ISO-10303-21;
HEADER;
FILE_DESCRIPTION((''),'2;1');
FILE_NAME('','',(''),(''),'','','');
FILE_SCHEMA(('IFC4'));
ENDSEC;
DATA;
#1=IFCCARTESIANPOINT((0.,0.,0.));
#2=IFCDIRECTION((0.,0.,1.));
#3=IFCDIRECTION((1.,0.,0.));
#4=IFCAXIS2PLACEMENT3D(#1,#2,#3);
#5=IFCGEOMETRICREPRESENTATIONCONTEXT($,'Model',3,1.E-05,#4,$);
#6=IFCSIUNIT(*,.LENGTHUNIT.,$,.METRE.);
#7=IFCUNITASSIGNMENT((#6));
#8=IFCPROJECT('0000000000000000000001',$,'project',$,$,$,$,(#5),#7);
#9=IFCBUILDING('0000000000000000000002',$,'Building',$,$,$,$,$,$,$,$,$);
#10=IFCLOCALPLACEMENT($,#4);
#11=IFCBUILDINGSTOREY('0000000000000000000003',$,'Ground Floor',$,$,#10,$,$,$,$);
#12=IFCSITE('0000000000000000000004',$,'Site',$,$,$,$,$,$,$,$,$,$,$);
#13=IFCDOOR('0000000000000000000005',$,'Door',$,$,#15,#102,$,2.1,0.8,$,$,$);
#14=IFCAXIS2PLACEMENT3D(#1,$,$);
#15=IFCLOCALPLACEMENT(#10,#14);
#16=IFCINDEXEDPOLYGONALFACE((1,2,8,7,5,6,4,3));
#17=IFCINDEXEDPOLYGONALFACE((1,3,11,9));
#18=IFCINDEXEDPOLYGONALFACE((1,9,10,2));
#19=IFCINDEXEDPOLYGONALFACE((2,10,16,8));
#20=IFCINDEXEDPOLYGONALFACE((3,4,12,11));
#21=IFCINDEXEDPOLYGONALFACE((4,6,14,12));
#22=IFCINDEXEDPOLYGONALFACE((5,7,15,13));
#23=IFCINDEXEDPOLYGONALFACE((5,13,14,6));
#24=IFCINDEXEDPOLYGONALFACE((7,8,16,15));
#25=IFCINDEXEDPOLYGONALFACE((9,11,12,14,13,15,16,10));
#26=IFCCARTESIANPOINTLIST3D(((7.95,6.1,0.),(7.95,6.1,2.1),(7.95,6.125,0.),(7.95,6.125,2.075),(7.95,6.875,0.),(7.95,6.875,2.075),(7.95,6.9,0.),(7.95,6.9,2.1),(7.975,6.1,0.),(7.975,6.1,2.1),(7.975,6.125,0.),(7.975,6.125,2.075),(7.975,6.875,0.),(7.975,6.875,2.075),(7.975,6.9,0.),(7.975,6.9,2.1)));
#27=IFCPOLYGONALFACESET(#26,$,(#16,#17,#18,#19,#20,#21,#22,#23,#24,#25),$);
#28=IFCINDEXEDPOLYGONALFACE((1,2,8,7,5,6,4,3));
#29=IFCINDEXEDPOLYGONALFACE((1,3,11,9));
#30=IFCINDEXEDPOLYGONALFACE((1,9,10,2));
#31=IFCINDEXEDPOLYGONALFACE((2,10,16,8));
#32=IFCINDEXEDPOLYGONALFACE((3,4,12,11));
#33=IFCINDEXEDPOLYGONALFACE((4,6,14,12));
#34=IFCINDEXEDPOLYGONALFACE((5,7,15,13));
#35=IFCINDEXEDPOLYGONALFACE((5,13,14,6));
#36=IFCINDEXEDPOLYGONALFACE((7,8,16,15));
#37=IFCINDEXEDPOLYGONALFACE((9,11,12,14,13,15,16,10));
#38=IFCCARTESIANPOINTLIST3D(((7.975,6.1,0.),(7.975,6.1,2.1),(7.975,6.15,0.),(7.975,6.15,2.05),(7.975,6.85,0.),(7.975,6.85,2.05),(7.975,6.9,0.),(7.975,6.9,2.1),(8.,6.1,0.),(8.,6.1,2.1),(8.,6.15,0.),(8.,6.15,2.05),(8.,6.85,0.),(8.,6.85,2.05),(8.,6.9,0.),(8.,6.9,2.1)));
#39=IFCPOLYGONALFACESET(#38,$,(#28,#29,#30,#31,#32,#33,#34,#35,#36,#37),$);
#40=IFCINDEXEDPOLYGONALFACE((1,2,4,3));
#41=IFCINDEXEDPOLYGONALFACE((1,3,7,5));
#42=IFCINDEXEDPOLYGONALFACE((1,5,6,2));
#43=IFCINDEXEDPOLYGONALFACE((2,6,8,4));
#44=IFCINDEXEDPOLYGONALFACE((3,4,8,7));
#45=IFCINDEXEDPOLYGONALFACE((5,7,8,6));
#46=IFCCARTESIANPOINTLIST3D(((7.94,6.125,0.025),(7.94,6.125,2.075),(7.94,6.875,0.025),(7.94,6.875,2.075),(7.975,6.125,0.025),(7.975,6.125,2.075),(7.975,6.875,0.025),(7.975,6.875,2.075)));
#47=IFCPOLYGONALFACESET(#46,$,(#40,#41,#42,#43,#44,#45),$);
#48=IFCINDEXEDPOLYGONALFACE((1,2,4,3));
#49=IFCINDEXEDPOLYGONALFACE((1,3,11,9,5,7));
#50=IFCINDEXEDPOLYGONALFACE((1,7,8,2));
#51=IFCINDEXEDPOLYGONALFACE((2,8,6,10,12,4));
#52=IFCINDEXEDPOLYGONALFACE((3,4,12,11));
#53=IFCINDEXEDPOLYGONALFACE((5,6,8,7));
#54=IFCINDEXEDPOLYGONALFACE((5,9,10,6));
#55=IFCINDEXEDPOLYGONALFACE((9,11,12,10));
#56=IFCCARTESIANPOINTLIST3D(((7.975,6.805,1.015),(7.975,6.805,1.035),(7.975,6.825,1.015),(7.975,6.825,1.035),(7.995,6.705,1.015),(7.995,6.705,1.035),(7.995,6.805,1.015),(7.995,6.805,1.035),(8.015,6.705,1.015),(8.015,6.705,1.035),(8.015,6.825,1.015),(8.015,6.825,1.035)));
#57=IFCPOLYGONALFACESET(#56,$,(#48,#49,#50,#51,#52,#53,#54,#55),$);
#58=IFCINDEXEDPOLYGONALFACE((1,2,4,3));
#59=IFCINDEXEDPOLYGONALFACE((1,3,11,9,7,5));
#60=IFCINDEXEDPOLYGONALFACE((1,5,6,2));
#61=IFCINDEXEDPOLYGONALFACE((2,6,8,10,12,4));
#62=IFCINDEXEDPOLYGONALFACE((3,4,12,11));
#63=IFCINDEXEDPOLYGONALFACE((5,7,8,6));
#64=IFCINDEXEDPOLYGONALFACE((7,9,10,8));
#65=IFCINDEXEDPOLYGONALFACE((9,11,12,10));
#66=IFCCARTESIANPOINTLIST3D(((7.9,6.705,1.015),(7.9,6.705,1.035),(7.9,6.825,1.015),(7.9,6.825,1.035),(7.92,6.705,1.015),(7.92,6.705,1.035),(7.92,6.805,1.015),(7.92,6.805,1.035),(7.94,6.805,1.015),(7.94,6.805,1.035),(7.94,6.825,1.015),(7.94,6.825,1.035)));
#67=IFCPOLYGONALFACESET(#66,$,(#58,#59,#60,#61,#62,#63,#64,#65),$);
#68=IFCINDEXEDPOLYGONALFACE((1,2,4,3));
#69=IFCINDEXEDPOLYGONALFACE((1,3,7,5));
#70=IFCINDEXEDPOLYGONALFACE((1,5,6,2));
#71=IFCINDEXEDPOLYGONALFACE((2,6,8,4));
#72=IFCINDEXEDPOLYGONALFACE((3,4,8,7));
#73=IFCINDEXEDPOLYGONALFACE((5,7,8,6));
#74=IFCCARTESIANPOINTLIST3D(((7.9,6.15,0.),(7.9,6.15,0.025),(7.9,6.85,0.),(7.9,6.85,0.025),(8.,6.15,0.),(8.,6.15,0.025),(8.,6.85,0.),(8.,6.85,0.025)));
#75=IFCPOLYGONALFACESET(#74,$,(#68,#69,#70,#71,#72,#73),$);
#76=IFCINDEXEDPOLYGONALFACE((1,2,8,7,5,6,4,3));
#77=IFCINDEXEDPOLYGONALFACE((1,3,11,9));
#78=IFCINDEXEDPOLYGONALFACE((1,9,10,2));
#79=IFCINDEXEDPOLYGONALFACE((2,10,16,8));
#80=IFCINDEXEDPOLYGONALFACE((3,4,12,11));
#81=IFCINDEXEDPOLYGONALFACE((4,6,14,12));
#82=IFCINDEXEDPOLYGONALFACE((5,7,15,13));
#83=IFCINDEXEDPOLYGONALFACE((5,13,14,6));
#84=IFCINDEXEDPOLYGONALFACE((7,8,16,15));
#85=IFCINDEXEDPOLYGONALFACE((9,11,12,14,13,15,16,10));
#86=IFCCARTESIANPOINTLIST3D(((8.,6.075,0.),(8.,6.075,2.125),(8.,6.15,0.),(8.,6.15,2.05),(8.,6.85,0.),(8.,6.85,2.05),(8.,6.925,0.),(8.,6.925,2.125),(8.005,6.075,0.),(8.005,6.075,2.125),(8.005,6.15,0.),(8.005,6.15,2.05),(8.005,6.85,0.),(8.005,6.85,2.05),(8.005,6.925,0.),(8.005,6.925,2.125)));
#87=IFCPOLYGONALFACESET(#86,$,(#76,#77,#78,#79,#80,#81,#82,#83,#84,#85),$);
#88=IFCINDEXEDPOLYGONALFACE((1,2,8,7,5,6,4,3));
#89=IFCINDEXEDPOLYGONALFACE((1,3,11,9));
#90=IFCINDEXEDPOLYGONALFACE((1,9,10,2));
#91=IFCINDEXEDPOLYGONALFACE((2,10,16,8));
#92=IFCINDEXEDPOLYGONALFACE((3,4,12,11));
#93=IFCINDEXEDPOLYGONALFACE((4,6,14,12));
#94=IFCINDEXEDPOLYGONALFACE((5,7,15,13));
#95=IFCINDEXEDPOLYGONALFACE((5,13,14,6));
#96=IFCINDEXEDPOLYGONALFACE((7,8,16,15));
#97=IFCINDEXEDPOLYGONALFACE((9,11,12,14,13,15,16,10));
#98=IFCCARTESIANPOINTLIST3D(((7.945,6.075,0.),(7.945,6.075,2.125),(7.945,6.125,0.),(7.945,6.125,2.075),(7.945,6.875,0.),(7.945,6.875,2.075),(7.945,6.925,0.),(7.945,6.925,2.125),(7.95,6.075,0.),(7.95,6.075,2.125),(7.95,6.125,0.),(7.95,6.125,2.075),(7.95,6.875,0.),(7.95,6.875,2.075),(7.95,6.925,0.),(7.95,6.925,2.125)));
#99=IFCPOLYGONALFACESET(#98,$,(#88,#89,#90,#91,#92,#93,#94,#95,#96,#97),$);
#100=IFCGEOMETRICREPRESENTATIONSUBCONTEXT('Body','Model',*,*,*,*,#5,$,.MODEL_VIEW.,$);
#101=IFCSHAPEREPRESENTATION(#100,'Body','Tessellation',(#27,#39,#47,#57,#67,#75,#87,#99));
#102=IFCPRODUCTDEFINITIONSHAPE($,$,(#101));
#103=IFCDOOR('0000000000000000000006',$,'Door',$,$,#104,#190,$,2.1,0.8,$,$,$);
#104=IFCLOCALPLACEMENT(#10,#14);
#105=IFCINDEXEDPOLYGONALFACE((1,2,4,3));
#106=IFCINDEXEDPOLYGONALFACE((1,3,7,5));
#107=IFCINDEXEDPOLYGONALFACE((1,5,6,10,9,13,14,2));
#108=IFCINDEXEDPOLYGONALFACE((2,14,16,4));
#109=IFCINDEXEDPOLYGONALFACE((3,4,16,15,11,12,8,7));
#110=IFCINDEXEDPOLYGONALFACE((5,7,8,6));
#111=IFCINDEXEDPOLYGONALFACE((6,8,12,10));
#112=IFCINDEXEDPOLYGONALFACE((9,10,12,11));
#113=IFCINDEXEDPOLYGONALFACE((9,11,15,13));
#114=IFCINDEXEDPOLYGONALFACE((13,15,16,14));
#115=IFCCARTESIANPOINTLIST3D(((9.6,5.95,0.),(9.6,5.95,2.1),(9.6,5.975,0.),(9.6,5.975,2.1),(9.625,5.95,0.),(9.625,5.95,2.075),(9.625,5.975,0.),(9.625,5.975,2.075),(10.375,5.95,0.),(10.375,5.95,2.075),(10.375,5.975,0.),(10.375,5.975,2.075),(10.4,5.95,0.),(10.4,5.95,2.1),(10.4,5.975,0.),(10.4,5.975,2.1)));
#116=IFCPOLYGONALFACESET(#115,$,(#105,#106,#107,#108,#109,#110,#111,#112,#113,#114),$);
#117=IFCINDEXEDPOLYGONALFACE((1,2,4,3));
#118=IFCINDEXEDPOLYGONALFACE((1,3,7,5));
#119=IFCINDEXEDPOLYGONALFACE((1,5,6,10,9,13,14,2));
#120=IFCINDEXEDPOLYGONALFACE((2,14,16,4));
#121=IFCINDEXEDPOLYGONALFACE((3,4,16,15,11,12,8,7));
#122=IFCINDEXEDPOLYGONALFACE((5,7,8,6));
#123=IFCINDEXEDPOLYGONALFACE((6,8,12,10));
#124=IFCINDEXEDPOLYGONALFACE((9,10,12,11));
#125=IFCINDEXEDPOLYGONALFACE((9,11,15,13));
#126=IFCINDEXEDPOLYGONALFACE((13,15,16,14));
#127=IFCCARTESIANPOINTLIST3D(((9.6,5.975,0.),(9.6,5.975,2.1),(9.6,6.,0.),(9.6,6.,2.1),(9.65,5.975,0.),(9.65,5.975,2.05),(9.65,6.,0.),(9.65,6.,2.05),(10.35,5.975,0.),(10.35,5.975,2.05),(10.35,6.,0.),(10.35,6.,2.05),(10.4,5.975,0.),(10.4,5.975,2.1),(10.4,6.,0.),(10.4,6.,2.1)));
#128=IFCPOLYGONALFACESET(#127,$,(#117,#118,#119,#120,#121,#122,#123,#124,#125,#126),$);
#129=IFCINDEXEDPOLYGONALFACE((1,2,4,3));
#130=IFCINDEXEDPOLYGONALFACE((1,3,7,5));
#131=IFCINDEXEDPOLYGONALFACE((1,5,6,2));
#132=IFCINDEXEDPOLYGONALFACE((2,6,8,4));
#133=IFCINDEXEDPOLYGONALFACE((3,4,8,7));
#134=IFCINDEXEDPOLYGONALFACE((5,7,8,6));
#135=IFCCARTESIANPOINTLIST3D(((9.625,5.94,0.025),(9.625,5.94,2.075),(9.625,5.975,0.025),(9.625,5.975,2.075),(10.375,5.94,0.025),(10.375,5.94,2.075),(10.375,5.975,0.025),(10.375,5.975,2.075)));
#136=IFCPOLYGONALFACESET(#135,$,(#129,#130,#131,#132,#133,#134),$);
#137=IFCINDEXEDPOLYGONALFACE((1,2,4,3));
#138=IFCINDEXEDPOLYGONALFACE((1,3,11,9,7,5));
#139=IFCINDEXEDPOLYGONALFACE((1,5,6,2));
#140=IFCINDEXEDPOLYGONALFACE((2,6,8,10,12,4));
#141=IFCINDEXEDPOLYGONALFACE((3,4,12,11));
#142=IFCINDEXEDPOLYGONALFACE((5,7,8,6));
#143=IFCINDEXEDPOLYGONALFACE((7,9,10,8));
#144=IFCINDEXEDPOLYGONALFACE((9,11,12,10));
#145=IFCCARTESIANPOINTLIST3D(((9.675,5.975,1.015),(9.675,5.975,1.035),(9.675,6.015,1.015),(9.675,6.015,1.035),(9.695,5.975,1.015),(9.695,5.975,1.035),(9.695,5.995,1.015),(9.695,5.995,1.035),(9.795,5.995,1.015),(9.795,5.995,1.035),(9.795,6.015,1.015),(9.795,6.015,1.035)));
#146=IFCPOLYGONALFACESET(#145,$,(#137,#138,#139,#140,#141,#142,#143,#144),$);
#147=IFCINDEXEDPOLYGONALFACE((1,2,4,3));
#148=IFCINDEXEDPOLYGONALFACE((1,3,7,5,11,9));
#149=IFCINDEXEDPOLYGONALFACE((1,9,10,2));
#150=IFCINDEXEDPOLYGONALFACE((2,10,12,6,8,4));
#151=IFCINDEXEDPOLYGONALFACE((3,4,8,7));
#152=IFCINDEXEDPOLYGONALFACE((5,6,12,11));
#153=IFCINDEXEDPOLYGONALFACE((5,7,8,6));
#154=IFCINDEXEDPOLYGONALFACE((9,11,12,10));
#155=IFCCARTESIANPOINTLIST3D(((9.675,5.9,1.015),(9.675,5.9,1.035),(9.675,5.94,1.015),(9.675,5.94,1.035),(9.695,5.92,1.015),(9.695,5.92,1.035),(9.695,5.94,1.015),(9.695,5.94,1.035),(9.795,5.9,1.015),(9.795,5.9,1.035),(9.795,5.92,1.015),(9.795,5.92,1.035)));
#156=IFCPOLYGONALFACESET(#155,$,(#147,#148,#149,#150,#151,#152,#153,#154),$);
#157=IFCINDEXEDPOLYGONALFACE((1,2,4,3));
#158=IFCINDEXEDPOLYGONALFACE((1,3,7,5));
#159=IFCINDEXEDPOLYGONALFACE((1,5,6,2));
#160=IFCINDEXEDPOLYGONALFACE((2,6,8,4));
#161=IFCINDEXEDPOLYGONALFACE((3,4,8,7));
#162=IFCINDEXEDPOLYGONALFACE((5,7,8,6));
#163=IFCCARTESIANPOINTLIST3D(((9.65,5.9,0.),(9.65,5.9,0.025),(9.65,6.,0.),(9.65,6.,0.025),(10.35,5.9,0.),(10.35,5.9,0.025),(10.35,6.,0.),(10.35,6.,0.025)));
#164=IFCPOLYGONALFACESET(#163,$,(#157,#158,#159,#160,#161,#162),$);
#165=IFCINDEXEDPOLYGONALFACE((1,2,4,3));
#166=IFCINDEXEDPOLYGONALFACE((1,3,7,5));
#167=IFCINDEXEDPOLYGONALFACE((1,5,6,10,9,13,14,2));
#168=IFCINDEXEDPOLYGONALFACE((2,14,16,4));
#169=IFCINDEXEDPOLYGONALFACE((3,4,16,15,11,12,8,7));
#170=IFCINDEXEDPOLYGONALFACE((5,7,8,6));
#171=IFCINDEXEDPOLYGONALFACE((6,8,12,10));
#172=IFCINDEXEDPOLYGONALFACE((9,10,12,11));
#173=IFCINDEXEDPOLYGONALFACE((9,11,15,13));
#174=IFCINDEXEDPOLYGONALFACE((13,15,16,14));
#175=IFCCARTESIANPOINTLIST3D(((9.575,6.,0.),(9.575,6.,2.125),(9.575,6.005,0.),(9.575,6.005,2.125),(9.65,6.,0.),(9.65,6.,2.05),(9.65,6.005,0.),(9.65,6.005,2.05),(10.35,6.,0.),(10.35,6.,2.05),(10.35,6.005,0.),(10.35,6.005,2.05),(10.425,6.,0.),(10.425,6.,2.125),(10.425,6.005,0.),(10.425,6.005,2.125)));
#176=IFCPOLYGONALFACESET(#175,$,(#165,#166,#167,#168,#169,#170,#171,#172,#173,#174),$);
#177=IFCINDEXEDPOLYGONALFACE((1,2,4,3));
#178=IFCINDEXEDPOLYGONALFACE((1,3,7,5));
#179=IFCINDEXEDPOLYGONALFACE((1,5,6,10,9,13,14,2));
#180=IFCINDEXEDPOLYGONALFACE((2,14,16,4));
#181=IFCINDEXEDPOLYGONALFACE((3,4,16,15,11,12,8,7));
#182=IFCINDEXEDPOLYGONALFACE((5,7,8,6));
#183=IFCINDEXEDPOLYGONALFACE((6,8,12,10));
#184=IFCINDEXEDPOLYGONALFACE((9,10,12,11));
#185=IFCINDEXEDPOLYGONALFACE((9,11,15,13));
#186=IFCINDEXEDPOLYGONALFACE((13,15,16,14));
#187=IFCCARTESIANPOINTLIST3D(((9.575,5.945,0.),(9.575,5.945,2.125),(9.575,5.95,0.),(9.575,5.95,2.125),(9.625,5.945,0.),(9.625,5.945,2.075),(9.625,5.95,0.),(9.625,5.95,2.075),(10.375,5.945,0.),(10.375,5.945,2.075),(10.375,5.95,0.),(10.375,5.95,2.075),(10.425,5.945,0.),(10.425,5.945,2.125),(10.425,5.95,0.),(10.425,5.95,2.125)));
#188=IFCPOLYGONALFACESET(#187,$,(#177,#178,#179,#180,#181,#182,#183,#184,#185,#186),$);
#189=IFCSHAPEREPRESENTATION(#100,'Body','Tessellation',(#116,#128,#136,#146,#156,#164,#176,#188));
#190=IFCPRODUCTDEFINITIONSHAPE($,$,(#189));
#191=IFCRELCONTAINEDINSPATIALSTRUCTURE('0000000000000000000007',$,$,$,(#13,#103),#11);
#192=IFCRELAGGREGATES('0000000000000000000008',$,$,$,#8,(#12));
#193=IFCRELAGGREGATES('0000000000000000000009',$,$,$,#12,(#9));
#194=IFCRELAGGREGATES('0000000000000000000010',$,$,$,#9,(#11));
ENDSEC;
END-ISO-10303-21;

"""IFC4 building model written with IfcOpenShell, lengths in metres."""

from ifc_helpers import new_model, si_unit, frame, origin_with_axes, place, context, subcontext, project, spatial, line, indexed_curve, outline, extrude, element, save


model = new_model("IFC4")

# Units and contexts
model_context = context("Model", 3, precision=1e-05, world=origin_with_axes())
body_context = subcontext(model_context, "Body", "Model", "MODEL_VIEW")
ifc_project = project(units=[si_unit("LENGTHUNIT", "METRE")], contexts=[model_context])

# Site, building, storey
site = spatial("IfcSite", under=ifc_project, Name="Site")
building = spatial("IfcBuilding", under=site, Name="Building")
storey_placement = place(None, origin_with_axes())
storey = spatial("IfcBuildingStorey", under=building, at=storey_placement, Name="Ground Floor")

# Doors
door_1_placement = place(storey_placement, frame((8.0, 6.1, 0.0), z_axis=(0.0, 0.0, 1.0), x_axis=(0.0, 1.0, 0.0)))
element("IfcDoor", 1, at=door_1_placement, inside=storey, Name="Door", OverallHeight=2.1, OverallWidth=0.8, context=body_context, shape_type="SweptSolid", body=[
    extrude(outline(indexed_curve([(0.0, 0.0), (0.0, 2.1), (0.8, 2.1), (0.8, 0.0), (0.775, 0.0), (0.775, 2.075), (0.025, 2.075), (0.025, 0.0)], segments=[line(1, 2, 3, 4, 5, 6, 7, 8, 1)])), frame((0.0, 0.025, 0.0), z_axis=(0.0, -1.0, 0.0), x_axis=(1.0, 0.0, 0.0)), (0.0, 0.0, -1.0), 0.025),
    extrude(outline(indexed_curve([(0.0, 0.0), (0.0, 2.1), (0.8, 2.1), (0.8, 0.0), (0.75, 0.0), (0.75, 2.05), (0.05, 2.05), (0.05, 0.0)], segments=[line(1, 2, 3, 4, 5, 6, 7, 8, 1)])), frame((0.0, 0.0, 0.0), z_axis=(0.0, -1.0, 0.0), x_axis=(1.0, 0.0, 0.0)), (0.0, 0.0, -1.0), 0.025),
    extrude(outline(indexed_curve([(0.0, 0.0), (0.75, 0.0), (0.75, 0.035), (0.0, 0.035)], segments=[line(1, 2, 3, 4, 1)])), frame((0.025, 0.025, 0.025), z_axis=(0.0, 0.0, 1.0), x_axis=(1.0, 0.0, 0.0)), (0.0, 0.0, 1.0), 2.05),
    extrude(outline(indexed_curve([(0.0, 0.0), (0.0, -0.04), (-0.12, -0.04), (-0.12, -0.02), (-0.02, -0.02), (-0.02, 0.0)], segments=[line(1, 2, 3, 4, 5, 6, 1)])), frame((0.725, 0.025, 1.015), z_axis=(0.0, 0.0, 1.0), x_axis=(1.0, 0.0, 0.0)), (0.0, 0.0, 1.0), 0.02),
    extrude(outline(indexed_curve([(0.0, 0.0), (0.0, 0.04), (-0.12, 0.04), (-0.12, 0.02), (-0.02, 0.02), (-0.02, 0.0)], segments=[line(1, 2, 3, 4, 5, 6, 1)])), frame((0.725, 0.06, 1.015), z_axis=(0.0, 0.0, 1.0), x_axis=(1.0, 0.0, 0.0)), (0.0, 0.0, 1.0), 0.02),
    extrude(outline(indexed_curve([(0.0, 0.0), (0.7, 0.0), (0.7, 0.1), (0.0, 0.1)], segments=[line(1, 2, 3, 4, 1)])), frame((0.05, 0.0, 0.0), z_axis=(0.0, 0.0, 1.0), x_axis=(1.0, 0.0, 0.0)), (0.0, 0.0, 1.0), 0.025),
    extrude(outline(indexed_curve([(0.0, 0.0), (0.0, 2.125), (0.85, 2.125), (0.85, 0.0), (0.775, 0.0), (0.775, 2.05), (0.075, 2.05), (0.075, 0.0)], segments=[line(1, 2, 3, 4, 5, 6, 7, 8, 1)])), frame((-0.025, -0.005, 0.0), z_axis=(0.0, -1.0, 0.0), x_axis=(1.0, 0.0, 0.0)), (0.0, 0.0, -1.0), 0.005),
    extrude(outline(indexed_curve([(0.0, 0.0), (0.0, 2.125), (0.85, 2.125), (0.85, 0.0), (0.8, 0.0), (0.8, 2.075), (0.05, 2.075), (0.05, 0.0)], segments=[line(1, 2, 3, 4, 5, 6, 7, 8, 1)])), frame((-0.025, 0.05, 0.0), z_axis=(0.0, -1.0, 0.0), x_axis=(1.0, 0.0, 0.0)), (0.0, 0.0, -1.0), 0.005),
])
door_2_placement = place(storey_placement, frame((10.4, 6.0, 0.0), z_axis=(0.0, 0.0, 1.0), x_axis=(-1.0, 0.0, 0.0)))
element("IfcDoor", 2, at=door_2_placement, inside=storey, Name="Door", OverallHeight=2.1, OverallWidth=0.8, context=body_context, shape_type="SweptSolid", body=[
    extrude(outline(indexed_curve([(0.0, 0.0), (0.0, 2.1), (0.8, 2.1), (0.8, 0.0), (0.775, 0.0), (0.775, 2.075), (0.025, 2.075), (0.025, 0.0)], segments=[line(1, 2, 3, 4, 5, 6, 7, 8, 1)])), frame((0.0, 0.025, 0.0), z_axis=(0.0, -1.0, 0.0), x_axis=(1.0, 0.0, 0.0)), (0.0, 0.0, -1.0), 0.025),
    extrude(outline(indexed_curve([(0.0, 0.0), (0.0, 2.1), (0.8, 2.1), (0.8, 0.0), (0.75, 0.0), (0.75, 2.05), (0.05, 2.05), (0.05, 0.0)], segments=[line(1, 2, 3, 4, 5, 6, 7, 8, 1)])), frame((0.0, 0.0, 0.0), z_axis=(0.0, -1.0, 0.0), x_axis=(1.0, 0.0, 0.0)), (0.0, 0.0, -1.0), 0.025),
    extrude(outline(indexed_curve([(0.0, 0.0), (0.75, 0.0), (0.75, 0.035), (0.0, 0.035)], segments=[line(1, 2, 3, 4, 1)])), frame((0.025, 0.025, 0.025), z_axis=(0.0, 0.0, 1.0), x_axis=(1.0, 0.0, 0.0)), (0.0, 0.0, 1.0), 2.05),
    extrude(outline(indexed_curve([(0.0, 0.0), (0.0, -0.04), (-0.12, -0.04), (-0.12, -0.02), (-0.02, -0.02), (-0.02, 0.0)], segments=[line(1, 2, 3, 4, 5, 6, 1)])), frame((0.725, 0.025, 1.015), z_axis=(0.0, 0.0, 1.0), x_axis=(1.0, 0.0, 0.0)), (0.0, 0.0, 1.0), 0.02),
    extrude(outline(indexed_curve([(0.0, 0.0), (0.0, 0.04), (-0.12, 0.04), (-0.12, 0.02), (-0.02, 0.02), (-0.02, 0.0)], segments=[line(1, 2, 3, 4, 5, 6, 1)])), frame((0.725, 0.06, 1.015), z_axis=(0.0, 0.0, 1.0), x_axis=(1.0, 0.0, 0.0)), (0.0, 0.0, 1.0), 0.02),
    extrude(outline(indexed_curve([(0.0, 0.0), (0.7, 0.0), (0.7, 0.1), (0.0, 0.1)], segments=[line(1, 2, 3, 4, 1)])), frame((0.05, 0.0, 0.0), z_axis=(0.0, 0.0, 1.0), x_axis=(1.0, 0.0, 0.0)), (0.0, 0.0, 1.0), 0.025),
    extrude(outline(indexed_curve([(0.0, 0.0), (0.0, 2.125), (0.85, 2.125), (0.85, 0.0), (0.775, 0.0), (0.775, 2.05), (0.075, 2.05), (0.075, 0.0)], segments=[line(1, 2, 3, 4, 5, 6, 7, 8, 1)])), frame((-0.025, -0.005, 0.0), z_axis=(0.0, -1.0, 0.0), x_axis=(1.0, 0.0, 0.0)), (0.0, 0.0, -1.0), 0.005),
    extrude(outline(indexed_curve([(0.0, 0.0), (0.0, 2.125), (0.85, 2.125), (0.85, 0.0), (0.8, 0.0), (0.8, 2.075), (0.05, 2.075), (0.05, 0.0)], segments=[line(1, 2, 3, 4, 5, 6, 7, 8, 1)])), frame((-0.025, 0.05, 0.0), z_axis=(0.0, -1.0, 0.0), x_axis=(1.0, 0.0, 0.0)), (0.0, 0.0, -1.0), 0.005),
])

save(model, "model.ifc")
